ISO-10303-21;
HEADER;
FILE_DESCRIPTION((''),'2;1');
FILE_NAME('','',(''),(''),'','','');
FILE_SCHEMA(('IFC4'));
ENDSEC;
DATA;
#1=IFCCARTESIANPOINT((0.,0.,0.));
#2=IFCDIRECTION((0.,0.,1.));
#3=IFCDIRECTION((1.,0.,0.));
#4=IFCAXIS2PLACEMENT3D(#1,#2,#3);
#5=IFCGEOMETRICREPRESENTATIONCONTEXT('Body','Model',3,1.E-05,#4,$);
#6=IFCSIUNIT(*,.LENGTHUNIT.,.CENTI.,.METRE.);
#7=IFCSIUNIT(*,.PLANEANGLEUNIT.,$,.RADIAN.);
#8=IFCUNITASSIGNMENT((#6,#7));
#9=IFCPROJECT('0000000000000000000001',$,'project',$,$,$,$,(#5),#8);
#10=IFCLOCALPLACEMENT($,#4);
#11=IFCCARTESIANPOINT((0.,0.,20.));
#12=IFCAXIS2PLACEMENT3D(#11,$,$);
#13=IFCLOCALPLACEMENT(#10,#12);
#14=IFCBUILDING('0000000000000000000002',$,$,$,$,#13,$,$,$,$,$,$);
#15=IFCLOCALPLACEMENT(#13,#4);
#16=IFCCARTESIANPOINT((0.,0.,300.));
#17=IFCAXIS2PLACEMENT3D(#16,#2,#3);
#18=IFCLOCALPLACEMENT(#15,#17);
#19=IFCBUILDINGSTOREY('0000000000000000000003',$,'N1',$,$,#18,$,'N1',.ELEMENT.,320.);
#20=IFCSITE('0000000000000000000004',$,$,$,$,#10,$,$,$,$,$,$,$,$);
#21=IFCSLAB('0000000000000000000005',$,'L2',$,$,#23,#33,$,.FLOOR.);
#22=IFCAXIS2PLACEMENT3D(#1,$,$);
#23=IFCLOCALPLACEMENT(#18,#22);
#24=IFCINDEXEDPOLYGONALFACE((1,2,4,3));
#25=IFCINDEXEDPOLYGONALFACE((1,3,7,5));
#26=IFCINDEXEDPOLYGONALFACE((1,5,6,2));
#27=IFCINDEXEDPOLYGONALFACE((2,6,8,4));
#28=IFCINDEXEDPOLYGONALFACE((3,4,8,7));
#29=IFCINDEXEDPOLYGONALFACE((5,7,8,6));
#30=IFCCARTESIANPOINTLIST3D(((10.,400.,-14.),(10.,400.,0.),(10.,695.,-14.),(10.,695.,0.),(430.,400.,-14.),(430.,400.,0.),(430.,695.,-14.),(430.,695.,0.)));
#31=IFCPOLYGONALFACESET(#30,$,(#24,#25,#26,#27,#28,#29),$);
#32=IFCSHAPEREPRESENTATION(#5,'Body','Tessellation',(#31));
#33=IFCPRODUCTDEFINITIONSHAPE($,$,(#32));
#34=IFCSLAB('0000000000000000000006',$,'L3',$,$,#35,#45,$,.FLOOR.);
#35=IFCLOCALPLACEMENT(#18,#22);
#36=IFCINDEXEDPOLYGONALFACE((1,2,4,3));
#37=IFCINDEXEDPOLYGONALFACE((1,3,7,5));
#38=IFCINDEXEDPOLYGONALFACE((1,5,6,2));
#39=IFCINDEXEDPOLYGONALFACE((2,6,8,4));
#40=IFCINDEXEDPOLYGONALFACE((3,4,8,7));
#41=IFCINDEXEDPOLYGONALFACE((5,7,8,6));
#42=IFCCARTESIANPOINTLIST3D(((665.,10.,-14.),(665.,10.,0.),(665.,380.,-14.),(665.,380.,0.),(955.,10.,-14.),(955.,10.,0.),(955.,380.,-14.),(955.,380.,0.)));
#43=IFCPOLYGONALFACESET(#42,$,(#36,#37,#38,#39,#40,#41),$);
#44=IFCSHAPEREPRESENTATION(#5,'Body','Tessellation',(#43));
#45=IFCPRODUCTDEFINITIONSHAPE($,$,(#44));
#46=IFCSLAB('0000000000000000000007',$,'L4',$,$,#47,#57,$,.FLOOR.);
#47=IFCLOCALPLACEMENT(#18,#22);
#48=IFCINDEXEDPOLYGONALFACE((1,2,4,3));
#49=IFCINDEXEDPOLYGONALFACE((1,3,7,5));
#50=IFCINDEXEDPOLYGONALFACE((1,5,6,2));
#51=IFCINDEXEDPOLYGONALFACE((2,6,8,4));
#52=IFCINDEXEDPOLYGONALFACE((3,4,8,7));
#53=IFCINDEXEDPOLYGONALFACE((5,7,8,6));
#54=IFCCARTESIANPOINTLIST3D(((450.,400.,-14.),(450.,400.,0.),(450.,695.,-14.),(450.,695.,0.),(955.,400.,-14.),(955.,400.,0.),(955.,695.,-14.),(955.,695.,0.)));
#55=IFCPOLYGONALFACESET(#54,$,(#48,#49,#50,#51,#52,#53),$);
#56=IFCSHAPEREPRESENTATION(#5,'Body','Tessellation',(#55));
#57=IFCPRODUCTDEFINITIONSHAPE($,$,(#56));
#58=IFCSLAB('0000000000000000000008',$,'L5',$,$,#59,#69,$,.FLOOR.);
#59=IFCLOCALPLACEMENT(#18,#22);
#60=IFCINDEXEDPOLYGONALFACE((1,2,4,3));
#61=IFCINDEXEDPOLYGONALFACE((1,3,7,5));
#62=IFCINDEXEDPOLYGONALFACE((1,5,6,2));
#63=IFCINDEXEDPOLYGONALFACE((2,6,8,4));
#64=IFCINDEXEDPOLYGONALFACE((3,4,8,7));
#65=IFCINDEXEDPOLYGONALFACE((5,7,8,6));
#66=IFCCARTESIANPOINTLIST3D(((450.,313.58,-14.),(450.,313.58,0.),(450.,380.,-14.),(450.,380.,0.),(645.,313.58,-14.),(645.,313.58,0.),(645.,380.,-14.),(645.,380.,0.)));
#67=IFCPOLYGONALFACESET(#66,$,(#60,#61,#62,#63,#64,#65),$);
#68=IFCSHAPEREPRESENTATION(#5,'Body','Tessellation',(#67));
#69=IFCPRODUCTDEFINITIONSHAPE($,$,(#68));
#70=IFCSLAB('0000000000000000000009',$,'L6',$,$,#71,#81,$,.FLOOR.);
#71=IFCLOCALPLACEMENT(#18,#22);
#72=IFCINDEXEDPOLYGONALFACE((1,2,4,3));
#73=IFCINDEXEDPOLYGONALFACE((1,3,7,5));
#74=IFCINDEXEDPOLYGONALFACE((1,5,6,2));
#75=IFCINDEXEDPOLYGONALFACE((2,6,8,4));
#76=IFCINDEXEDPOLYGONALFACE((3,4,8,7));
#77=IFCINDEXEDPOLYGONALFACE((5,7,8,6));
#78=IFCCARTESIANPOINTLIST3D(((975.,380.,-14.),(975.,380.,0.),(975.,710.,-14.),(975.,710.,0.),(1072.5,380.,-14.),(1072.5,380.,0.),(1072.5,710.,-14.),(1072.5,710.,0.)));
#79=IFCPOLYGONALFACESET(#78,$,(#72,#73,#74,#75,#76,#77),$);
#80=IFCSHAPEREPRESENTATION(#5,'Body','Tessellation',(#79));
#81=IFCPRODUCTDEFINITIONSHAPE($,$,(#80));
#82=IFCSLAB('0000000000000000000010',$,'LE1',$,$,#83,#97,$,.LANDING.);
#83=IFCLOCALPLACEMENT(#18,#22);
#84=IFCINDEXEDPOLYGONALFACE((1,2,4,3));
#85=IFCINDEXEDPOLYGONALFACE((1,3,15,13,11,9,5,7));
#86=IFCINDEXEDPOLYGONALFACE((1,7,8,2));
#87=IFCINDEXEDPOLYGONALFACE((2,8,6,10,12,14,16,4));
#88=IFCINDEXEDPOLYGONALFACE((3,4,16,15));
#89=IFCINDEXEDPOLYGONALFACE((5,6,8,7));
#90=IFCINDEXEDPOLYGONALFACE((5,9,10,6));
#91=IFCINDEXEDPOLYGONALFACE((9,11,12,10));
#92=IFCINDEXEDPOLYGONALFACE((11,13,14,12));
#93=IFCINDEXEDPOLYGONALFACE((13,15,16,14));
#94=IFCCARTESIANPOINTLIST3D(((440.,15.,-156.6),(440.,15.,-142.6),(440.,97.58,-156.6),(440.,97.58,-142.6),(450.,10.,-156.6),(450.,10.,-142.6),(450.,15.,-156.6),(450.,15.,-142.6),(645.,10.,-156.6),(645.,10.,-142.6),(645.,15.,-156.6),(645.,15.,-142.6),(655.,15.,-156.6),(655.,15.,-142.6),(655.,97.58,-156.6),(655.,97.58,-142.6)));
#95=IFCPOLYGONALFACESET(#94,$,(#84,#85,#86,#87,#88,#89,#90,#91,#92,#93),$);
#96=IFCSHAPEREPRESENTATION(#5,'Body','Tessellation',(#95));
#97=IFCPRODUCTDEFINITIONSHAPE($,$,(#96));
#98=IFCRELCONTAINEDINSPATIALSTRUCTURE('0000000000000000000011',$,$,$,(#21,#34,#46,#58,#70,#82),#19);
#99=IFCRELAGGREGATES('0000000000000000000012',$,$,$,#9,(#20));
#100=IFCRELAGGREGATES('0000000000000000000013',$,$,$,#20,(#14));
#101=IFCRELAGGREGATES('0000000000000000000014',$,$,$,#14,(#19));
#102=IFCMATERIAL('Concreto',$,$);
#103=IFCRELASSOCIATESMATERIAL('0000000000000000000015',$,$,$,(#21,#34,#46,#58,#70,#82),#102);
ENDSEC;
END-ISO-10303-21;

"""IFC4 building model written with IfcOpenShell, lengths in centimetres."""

from ifc_helpers import new_model, si_unit, frame, origin_with_axes, place, context, project, spatial, polyline, outline, extrude, material, element, save


model = new_model("IFC4")

# Units and contexts
model_context = context("Model", 3, precision=1e-05, world=origin_with_axes(), identifier="Body")
ifc_project = project(units=[si_unit("LENGTHUNIT", "METRE", prefix="CENTI"), si_unit("PLANEANGLEUNIT", "RADIAN")], contexts=[model_context])

# Site, building, storey
site_placement = place(None, origin_with_axes())
site = spatial("IfcSite", under=ifc_project, at=site_placement)
building_placement = place(site_placement, frame((0.0, 0.0, 20.0)))
building = spatial("IfcBuilding", under=site, at=building_placement)
placement = place(building_placement, origin_with_axes())
storey_placement = place(placement, frame((0.0, 0.0, 300.0), z_axis=(0.0, 0.0, 1.0), x_axis=(1.0, 0.0, 0.0)))
storey = spatial("IfcBuildingStorey", under=building, at=storey_placement, Name="N1", LongName="N1", CompositionType="ELEMENT", Elevation=320.0)

# Shared definitions
ifc_material = material(Name="Concreto")

# Slabs
slab_1_placement = place(storey_placement, frame((220.0, 547.5, 0.0), z_axis=(0.0, 0.0, 1.0), x_axis=(1.0, 0.0, 0.0)))
element("IfcSlab", 1, at=slab_1_placement, inside=storey, material=ifc_material, Name="L2", PredefinedType="FLOOR", context=model_context, shape_type="SolidModel", body=[
    extrude(outline(polyline([(210.0, 147.5), (-210.0, 147.5), (-210.0, -147.5), (210.0, -147.5), (210.0, 147.5), (210.0, 147.5)])), frame((0.0, 0.0, -14.0), z_axis=(0.0, 0.0, 1.0), x_axis=(1.0, 0.0, 0.0)), (0.0, 0.0, 1.0), 14.0),
])
slab_2_placement = place(storey_placement, frame((810.0, 195.0, 0.0), z_axis=(0.0, 0.0, 1.0), x_axis=(1.0, 0.0, 0.0)))
element("IfcSlab", 2, at=slab_2_placement, inside=storey, material=ifc_material, Name="L3", PredefinedType="FLOOR", context=model_context, shape_type="SolidModel", body=[
    extrude(outline(polyline([(145.0, 185.0), (-145.0, 185.0), (-145.0, -185.0), (145.0, -185.0), (145.0, 185.0), (145.0, 185.0)])), frame((0.0, 0.0, -14.0), z_axis=(0.0, 0.0, 1.0), x_axis=(1.0, 0.0, 0.0)), (0.0, 0.0, 1.0), 14.0),
])
slab_3_placement = place(storey_placement, frame((702.5, 547.5, 0.0), z_axis=(0.0, 0.0, 1.0), x_axis=(1.0, 0.0, 0.0)))
element("IfcSlab", 3, at=slab_3_placement, inside=storey, material=ifc_material, Name="L4", PredefinedType="FLOOR", context=model_context, shape_type="SolidModel", body=[
    extrude(outline(polyline([(252.5, 147.5), (-252.5, 147.5), (-252.5, -147.5), (252.5, -147.5), (252.5, 147.5), (252.5, 147.5)])), frame((0.0, 0.0, -14.0), z_axis=(0.0, 0.0, 1.0), x_axis=(1.0, 0.0, 0.0)), (0.0, 0.0, 1.0), 14.0),
])
slab_4_placement = place(storey_placement, frame((547.5, 346.79, 0.0), z_axis=(0.0, 0.0, 1.0), x_axis=(1.0, 0.0, 0.0)))
element("IfcSlab", 4, at=slab_4_placement, inside=storey, material=ifc_material, Name="L5", PredefinedType="FLOOR", context=model_context, shape_type="SolidModel", body=[
    extrude(outline(polyline([(97.5, 33.21), (-97.5, 33.21), (-97.5, -33.21), (97.5, -33.21), (97.5, 33.21), (97.5, 33.21)])), frame((0.0, 0.0, -14.0), z_axis=(0.0, 0.0, 1.0), x_axis=(1.0, 0.0, 0.0)), (0.0, 0.0, 1.0), 14.0),
])
slab_5_placement = place(storey_placement, frame((1023.75, 545.0, 0.0), z_axis=(0.0, 0.0, 1.0), x_axis=(1.0, 0.0, 0.0)))
element("IfcSlab", 5, at=slab_5_placement, inside=storey, material=ifc_material, Name="L6", PredefinedType="FLOOR", context=model_context, shape_type="SolidModel", body=[
    extrude(outline(polyline([(48.75, 165.0), (-48.75, 165.0), (-48.75, -165.0), (48.75, -165.0), (48.75, 165.0), (48.75, 165.0)])), frame((0.0, 0.0, -14.0), z_axis=(0.0, 0.0, 1.0), x_axis=(1.0, 0.0, 0.0)), (0.0, 0.0, 1.0), 14.0),
])
slab_6_placement = place(storey_placement, frame((547.5, 53.79, -142.6), z_axis=(0.0, 0.0, 1.0), x_axis=(1.0, 0.0, 0.0)))
element("IfcSlab", 6, at=slab_6_placement, inside=storey, material=ifc_material, Name="LE1", PredefinedType="LANDING", context=model_context, shape_type="SolidModel", body=[
    extrude(outline(polyline([(97.5, -38.79), (107.5, -38.79), (107.5, 43.79), (-107.5, 43.79), (-107.5, -38.79), (-97.5, -38.79), (-97.5, -43.79), (97.5, -43.79), (97.5, -38.79), (97.5, -38.79)])), frame((0.0, 0.0, -14.0), z_axis=(0.0, 0.0, 1.0), x_axis=(1.0, 0.0, 0.0)), (0.0, 0.0, 1.0), 14.0),
])

save(model, "model.ifc")
